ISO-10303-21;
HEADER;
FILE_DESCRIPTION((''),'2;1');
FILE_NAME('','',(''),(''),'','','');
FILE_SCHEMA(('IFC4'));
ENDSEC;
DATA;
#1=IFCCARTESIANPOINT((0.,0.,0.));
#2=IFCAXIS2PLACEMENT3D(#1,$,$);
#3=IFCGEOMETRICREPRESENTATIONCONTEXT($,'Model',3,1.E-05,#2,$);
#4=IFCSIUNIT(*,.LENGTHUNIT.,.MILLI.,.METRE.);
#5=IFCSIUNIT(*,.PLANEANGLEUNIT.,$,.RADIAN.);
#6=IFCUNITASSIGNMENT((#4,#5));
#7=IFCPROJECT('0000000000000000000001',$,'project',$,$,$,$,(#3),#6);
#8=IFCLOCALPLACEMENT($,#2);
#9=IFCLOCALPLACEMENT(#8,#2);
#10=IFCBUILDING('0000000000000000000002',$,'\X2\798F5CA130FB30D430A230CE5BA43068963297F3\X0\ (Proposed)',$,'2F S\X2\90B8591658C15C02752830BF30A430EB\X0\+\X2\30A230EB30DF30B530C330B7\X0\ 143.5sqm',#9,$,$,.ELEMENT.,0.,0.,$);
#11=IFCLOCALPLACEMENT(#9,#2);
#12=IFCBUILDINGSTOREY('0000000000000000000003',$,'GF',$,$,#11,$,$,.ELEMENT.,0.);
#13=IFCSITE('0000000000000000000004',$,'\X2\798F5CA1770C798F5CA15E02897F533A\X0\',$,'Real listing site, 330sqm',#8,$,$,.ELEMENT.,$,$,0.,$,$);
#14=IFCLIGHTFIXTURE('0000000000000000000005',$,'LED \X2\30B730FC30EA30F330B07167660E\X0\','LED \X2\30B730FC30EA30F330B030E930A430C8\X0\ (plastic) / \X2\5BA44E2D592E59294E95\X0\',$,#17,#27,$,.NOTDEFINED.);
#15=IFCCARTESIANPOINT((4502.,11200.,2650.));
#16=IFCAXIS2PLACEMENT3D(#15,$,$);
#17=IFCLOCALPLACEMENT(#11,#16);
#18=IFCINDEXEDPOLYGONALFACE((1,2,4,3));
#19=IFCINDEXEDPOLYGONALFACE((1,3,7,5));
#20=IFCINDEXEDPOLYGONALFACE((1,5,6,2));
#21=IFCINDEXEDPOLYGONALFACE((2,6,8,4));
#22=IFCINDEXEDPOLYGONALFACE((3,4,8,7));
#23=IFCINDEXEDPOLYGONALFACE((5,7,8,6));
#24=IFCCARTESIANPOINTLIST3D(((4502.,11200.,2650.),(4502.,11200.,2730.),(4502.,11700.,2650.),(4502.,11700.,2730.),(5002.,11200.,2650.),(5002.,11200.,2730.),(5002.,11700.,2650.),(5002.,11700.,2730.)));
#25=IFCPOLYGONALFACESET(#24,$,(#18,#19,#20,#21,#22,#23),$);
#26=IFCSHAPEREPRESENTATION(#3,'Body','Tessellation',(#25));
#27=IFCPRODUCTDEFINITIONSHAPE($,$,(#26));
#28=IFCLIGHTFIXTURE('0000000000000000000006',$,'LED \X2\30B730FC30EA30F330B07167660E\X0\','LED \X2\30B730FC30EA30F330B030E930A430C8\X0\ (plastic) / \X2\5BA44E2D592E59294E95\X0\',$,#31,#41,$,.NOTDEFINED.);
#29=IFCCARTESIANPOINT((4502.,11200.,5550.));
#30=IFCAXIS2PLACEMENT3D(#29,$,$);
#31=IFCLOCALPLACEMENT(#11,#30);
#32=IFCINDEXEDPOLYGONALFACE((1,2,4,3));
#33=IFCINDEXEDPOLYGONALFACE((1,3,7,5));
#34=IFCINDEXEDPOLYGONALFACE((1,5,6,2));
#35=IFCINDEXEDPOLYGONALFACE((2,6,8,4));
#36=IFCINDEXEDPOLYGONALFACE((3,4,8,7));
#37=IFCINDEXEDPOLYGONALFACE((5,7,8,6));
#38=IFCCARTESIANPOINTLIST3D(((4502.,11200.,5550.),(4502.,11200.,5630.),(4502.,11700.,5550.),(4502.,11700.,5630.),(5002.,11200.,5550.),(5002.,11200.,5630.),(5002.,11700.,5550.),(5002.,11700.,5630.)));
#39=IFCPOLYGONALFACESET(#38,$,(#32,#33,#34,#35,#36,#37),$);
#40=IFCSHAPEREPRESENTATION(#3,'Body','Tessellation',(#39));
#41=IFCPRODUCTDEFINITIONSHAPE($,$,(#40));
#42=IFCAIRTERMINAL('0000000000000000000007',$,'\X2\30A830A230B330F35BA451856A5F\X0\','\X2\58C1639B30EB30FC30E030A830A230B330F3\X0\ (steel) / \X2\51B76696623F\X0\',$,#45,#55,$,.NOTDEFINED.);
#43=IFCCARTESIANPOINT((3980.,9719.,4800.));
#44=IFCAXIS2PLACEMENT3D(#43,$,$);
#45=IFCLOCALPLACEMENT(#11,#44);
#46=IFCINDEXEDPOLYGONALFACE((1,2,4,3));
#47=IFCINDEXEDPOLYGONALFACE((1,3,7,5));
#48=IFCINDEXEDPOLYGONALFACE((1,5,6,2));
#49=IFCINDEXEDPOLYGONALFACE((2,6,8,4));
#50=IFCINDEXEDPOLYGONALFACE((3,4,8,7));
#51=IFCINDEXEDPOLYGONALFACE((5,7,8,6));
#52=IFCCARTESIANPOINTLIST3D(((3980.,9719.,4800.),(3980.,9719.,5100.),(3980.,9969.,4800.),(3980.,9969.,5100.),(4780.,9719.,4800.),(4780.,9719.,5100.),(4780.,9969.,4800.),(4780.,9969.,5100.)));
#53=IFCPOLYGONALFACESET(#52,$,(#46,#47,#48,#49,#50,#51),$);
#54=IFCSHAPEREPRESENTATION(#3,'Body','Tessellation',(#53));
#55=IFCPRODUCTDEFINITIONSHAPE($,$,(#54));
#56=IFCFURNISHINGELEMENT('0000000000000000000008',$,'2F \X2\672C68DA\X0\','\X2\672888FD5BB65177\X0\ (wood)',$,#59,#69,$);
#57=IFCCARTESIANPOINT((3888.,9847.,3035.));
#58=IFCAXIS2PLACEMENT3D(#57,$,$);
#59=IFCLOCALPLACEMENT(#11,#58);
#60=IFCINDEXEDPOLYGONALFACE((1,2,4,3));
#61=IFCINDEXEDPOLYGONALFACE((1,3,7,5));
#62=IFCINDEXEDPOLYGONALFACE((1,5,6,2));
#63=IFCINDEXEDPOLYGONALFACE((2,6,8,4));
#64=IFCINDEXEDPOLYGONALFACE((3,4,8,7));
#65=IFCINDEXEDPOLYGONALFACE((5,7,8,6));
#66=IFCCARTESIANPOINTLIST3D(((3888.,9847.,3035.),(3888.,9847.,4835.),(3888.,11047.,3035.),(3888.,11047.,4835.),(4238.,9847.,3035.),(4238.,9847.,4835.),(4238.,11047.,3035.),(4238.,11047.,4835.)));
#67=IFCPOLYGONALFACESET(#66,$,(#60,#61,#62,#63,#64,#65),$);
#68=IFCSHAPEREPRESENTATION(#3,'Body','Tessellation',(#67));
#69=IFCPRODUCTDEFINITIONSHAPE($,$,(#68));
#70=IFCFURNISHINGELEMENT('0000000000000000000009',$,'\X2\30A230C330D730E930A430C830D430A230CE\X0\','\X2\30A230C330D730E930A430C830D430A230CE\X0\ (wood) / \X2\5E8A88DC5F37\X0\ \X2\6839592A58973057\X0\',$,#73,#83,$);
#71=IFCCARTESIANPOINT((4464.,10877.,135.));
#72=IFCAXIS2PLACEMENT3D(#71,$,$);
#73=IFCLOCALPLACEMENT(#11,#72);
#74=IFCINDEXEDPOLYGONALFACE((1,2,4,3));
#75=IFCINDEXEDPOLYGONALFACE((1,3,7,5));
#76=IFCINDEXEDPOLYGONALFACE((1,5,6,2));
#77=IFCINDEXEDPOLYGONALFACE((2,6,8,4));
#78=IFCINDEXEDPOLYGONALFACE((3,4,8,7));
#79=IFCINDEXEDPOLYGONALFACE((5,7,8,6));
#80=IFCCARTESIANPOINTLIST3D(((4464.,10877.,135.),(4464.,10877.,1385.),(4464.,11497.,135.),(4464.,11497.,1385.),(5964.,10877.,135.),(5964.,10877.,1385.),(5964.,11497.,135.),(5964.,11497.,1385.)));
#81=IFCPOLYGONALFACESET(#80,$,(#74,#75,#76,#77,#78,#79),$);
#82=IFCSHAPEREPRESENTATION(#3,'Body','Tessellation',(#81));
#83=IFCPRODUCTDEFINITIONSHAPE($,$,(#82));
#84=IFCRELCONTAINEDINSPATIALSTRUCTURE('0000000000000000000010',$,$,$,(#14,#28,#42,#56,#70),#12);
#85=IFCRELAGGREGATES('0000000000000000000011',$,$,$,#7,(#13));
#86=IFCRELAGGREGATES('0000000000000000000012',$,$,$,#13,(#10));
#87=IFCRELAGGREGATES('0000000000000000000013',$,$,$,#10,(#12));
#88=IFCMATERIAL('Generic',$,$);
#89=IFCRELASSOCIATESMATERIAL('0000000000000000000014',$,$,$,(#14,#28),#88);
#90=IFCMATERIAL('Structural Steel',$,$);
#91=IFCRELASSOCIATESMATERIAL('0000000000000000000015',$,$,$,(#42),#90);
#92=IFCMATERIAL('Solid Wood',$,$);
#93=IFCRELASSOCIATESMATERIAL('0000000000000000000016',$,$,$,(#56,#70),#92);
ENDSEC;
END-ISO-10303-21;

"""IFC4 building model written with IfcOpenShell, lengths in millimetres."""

from ifc_helpers import new_model, si_unit, frame, frame_2d, origin, place, context, project, spatial, rectangle, extrude, material, element, save


model = new_model("IFC4")

# Units and contexts
model_context = context("Model", 3, precision=1e-05, world=origin())
ifc_project = project(units=[si_unit("LENGTHUNIT", "METRE", prefix="MILLI"), si_unit("PLANEANGLEUNIT", "RADIAN")], contexts=[model_context])

# Site, building, storey
site_placement = place(None, origin())
site = spatial("IfcSite", under=ifc_project, at=site_placement, Name="福岡県福岡市西区", ObjectType="Real listing site, 330sqm", CompositionType="ELEMENT", RefElevation=0.0)
building_placement = place(site_placement, origin())
building = spatial("IfcBuilding", under=site, at=building_placement, Name="福岡・ピアノ室と防音 (Proposed)", ObjectType="2F S邸外壁専用タイル+アルミサッシ 143.5sqm", CompositionType="ELEMENT", ElevationOfRefHeight=0.0, ElevationOfTerrain=0.0)
storey_placement = place(building_placement, origin())
storey = spatial("IfcBuildingStorey", under=building, at=storey_placement, Name="GF", CompositionType="ELEMENT", Elevation=0.0)

# Shared definitions
ifc_material_1 = material(Name="Solid Wood")

# Shared definitions
ifc_material_2 = material(Name="Structural Steel")

# Shared definitions
ifc_material_3 = material(Name="Generic")

# Light fixtures
light_fixture_1_placement = place(storey_placement, frame((4502.0, 11200.0, 2650.0)))
element("IfcLightFixture", 1, at=light_fixture_1_placement, inside=storey, material=ifc_material_3, Name="LED シーリング照明", Description="LED シーリングライト (plastic) / 室中央天井", PredefinedType="NOTDEFINED", context=model_context, shape_type="SweptSolid", body=[
    extrude(rectangle(XDim=500.0, YDim=500.0, at=frame_2d((250.0, 250.0))), frame((4502.0, 11200.0, 2650.0)), (0.0, 0.0, 1.0), 80.0),
])
light_fixture_2_placement = place(storey_placement, frame((4502.0, 11200.0, 5550.0)))
element("IfcLightFixture", 2, at=light_fixture_2_placement, inside=storey, material=ifc_material_3, Name="LED シーリング照明", Description="LED シーリングライト (plastic) / 室中央天井", PredefinedType="NOTDEFINED", context=model_context, shape_type="SweptSolid", body=[
    extrude(rectangle(XDim=500.0, YDim=500.0, at=frame_2d((250.0, 250.0))), frame((4502.0, 11200.0, 5550.0)), (0.0, 0.0, 1.0), 80.0),
])

# Air terminal
air_terminal_placement = place(storey_placement, frame((3980.0, 9719.0, 4800.0)))
element("IfcAirTerminal", 3, at=air_terminal_placement, inside=storey, material=ifc_material_2, Name="エアコン室内機", Description="壁掛ルームエアコン (steel) / 冷暖房", PredefinedType="NOTDEFINED", context=model_context, shape_type="SweptSolid", body=[
    extrude(rectangle(XDim=800.0, YDim=250.0, at=frame_2d((400.0, 125.0))), frame((3980.0, 9719.0, 4800.0)), (0.0, 0.0, 1.0), 300.0),
])

# Furnishing elements
furnishing_1_placement = place(storey_placement, frame((3888.0, 9847.0, 3035.0)))
element("IfcFurnishingElement", 4, at=furnishing_1_placement, inside=storey, material=ifc_material_1, Name="2F 本棚", Description="木製家具 (wood)", context=model_context, shape_type="SweptSolid", body=[
    extrude(rectangle(XDim=350.0, YDim=1200.0, at=frame_2d((175.0, 600.0))), frame((3888.0, 9847.0, 3035.0)), (0.0, 0.0, 1.0), 1800.0),
])
furnishing_2_placement = place(storey_placement, frame((4464.0, 10877.0, 135.0)))
element("IfcFurnishingElement", 5, at=furnishing_2_placement, inside=storey, material=ifc_material_1, Name="アップライトピアノ", Description="アップライトピアノ (wood) / 床補強 根太増し", context=model_context, shape_type="SweptSolid", body=[
    extrude(rectangle(XDim=1500.0, YDim=620.0, at=frame_2d((750.0, 310.0))), frame((4464.0, 10877.0, 135.0)), (0.0, 0.0, 1.0), 1250.0),
])

save(model, "model.ifc")
